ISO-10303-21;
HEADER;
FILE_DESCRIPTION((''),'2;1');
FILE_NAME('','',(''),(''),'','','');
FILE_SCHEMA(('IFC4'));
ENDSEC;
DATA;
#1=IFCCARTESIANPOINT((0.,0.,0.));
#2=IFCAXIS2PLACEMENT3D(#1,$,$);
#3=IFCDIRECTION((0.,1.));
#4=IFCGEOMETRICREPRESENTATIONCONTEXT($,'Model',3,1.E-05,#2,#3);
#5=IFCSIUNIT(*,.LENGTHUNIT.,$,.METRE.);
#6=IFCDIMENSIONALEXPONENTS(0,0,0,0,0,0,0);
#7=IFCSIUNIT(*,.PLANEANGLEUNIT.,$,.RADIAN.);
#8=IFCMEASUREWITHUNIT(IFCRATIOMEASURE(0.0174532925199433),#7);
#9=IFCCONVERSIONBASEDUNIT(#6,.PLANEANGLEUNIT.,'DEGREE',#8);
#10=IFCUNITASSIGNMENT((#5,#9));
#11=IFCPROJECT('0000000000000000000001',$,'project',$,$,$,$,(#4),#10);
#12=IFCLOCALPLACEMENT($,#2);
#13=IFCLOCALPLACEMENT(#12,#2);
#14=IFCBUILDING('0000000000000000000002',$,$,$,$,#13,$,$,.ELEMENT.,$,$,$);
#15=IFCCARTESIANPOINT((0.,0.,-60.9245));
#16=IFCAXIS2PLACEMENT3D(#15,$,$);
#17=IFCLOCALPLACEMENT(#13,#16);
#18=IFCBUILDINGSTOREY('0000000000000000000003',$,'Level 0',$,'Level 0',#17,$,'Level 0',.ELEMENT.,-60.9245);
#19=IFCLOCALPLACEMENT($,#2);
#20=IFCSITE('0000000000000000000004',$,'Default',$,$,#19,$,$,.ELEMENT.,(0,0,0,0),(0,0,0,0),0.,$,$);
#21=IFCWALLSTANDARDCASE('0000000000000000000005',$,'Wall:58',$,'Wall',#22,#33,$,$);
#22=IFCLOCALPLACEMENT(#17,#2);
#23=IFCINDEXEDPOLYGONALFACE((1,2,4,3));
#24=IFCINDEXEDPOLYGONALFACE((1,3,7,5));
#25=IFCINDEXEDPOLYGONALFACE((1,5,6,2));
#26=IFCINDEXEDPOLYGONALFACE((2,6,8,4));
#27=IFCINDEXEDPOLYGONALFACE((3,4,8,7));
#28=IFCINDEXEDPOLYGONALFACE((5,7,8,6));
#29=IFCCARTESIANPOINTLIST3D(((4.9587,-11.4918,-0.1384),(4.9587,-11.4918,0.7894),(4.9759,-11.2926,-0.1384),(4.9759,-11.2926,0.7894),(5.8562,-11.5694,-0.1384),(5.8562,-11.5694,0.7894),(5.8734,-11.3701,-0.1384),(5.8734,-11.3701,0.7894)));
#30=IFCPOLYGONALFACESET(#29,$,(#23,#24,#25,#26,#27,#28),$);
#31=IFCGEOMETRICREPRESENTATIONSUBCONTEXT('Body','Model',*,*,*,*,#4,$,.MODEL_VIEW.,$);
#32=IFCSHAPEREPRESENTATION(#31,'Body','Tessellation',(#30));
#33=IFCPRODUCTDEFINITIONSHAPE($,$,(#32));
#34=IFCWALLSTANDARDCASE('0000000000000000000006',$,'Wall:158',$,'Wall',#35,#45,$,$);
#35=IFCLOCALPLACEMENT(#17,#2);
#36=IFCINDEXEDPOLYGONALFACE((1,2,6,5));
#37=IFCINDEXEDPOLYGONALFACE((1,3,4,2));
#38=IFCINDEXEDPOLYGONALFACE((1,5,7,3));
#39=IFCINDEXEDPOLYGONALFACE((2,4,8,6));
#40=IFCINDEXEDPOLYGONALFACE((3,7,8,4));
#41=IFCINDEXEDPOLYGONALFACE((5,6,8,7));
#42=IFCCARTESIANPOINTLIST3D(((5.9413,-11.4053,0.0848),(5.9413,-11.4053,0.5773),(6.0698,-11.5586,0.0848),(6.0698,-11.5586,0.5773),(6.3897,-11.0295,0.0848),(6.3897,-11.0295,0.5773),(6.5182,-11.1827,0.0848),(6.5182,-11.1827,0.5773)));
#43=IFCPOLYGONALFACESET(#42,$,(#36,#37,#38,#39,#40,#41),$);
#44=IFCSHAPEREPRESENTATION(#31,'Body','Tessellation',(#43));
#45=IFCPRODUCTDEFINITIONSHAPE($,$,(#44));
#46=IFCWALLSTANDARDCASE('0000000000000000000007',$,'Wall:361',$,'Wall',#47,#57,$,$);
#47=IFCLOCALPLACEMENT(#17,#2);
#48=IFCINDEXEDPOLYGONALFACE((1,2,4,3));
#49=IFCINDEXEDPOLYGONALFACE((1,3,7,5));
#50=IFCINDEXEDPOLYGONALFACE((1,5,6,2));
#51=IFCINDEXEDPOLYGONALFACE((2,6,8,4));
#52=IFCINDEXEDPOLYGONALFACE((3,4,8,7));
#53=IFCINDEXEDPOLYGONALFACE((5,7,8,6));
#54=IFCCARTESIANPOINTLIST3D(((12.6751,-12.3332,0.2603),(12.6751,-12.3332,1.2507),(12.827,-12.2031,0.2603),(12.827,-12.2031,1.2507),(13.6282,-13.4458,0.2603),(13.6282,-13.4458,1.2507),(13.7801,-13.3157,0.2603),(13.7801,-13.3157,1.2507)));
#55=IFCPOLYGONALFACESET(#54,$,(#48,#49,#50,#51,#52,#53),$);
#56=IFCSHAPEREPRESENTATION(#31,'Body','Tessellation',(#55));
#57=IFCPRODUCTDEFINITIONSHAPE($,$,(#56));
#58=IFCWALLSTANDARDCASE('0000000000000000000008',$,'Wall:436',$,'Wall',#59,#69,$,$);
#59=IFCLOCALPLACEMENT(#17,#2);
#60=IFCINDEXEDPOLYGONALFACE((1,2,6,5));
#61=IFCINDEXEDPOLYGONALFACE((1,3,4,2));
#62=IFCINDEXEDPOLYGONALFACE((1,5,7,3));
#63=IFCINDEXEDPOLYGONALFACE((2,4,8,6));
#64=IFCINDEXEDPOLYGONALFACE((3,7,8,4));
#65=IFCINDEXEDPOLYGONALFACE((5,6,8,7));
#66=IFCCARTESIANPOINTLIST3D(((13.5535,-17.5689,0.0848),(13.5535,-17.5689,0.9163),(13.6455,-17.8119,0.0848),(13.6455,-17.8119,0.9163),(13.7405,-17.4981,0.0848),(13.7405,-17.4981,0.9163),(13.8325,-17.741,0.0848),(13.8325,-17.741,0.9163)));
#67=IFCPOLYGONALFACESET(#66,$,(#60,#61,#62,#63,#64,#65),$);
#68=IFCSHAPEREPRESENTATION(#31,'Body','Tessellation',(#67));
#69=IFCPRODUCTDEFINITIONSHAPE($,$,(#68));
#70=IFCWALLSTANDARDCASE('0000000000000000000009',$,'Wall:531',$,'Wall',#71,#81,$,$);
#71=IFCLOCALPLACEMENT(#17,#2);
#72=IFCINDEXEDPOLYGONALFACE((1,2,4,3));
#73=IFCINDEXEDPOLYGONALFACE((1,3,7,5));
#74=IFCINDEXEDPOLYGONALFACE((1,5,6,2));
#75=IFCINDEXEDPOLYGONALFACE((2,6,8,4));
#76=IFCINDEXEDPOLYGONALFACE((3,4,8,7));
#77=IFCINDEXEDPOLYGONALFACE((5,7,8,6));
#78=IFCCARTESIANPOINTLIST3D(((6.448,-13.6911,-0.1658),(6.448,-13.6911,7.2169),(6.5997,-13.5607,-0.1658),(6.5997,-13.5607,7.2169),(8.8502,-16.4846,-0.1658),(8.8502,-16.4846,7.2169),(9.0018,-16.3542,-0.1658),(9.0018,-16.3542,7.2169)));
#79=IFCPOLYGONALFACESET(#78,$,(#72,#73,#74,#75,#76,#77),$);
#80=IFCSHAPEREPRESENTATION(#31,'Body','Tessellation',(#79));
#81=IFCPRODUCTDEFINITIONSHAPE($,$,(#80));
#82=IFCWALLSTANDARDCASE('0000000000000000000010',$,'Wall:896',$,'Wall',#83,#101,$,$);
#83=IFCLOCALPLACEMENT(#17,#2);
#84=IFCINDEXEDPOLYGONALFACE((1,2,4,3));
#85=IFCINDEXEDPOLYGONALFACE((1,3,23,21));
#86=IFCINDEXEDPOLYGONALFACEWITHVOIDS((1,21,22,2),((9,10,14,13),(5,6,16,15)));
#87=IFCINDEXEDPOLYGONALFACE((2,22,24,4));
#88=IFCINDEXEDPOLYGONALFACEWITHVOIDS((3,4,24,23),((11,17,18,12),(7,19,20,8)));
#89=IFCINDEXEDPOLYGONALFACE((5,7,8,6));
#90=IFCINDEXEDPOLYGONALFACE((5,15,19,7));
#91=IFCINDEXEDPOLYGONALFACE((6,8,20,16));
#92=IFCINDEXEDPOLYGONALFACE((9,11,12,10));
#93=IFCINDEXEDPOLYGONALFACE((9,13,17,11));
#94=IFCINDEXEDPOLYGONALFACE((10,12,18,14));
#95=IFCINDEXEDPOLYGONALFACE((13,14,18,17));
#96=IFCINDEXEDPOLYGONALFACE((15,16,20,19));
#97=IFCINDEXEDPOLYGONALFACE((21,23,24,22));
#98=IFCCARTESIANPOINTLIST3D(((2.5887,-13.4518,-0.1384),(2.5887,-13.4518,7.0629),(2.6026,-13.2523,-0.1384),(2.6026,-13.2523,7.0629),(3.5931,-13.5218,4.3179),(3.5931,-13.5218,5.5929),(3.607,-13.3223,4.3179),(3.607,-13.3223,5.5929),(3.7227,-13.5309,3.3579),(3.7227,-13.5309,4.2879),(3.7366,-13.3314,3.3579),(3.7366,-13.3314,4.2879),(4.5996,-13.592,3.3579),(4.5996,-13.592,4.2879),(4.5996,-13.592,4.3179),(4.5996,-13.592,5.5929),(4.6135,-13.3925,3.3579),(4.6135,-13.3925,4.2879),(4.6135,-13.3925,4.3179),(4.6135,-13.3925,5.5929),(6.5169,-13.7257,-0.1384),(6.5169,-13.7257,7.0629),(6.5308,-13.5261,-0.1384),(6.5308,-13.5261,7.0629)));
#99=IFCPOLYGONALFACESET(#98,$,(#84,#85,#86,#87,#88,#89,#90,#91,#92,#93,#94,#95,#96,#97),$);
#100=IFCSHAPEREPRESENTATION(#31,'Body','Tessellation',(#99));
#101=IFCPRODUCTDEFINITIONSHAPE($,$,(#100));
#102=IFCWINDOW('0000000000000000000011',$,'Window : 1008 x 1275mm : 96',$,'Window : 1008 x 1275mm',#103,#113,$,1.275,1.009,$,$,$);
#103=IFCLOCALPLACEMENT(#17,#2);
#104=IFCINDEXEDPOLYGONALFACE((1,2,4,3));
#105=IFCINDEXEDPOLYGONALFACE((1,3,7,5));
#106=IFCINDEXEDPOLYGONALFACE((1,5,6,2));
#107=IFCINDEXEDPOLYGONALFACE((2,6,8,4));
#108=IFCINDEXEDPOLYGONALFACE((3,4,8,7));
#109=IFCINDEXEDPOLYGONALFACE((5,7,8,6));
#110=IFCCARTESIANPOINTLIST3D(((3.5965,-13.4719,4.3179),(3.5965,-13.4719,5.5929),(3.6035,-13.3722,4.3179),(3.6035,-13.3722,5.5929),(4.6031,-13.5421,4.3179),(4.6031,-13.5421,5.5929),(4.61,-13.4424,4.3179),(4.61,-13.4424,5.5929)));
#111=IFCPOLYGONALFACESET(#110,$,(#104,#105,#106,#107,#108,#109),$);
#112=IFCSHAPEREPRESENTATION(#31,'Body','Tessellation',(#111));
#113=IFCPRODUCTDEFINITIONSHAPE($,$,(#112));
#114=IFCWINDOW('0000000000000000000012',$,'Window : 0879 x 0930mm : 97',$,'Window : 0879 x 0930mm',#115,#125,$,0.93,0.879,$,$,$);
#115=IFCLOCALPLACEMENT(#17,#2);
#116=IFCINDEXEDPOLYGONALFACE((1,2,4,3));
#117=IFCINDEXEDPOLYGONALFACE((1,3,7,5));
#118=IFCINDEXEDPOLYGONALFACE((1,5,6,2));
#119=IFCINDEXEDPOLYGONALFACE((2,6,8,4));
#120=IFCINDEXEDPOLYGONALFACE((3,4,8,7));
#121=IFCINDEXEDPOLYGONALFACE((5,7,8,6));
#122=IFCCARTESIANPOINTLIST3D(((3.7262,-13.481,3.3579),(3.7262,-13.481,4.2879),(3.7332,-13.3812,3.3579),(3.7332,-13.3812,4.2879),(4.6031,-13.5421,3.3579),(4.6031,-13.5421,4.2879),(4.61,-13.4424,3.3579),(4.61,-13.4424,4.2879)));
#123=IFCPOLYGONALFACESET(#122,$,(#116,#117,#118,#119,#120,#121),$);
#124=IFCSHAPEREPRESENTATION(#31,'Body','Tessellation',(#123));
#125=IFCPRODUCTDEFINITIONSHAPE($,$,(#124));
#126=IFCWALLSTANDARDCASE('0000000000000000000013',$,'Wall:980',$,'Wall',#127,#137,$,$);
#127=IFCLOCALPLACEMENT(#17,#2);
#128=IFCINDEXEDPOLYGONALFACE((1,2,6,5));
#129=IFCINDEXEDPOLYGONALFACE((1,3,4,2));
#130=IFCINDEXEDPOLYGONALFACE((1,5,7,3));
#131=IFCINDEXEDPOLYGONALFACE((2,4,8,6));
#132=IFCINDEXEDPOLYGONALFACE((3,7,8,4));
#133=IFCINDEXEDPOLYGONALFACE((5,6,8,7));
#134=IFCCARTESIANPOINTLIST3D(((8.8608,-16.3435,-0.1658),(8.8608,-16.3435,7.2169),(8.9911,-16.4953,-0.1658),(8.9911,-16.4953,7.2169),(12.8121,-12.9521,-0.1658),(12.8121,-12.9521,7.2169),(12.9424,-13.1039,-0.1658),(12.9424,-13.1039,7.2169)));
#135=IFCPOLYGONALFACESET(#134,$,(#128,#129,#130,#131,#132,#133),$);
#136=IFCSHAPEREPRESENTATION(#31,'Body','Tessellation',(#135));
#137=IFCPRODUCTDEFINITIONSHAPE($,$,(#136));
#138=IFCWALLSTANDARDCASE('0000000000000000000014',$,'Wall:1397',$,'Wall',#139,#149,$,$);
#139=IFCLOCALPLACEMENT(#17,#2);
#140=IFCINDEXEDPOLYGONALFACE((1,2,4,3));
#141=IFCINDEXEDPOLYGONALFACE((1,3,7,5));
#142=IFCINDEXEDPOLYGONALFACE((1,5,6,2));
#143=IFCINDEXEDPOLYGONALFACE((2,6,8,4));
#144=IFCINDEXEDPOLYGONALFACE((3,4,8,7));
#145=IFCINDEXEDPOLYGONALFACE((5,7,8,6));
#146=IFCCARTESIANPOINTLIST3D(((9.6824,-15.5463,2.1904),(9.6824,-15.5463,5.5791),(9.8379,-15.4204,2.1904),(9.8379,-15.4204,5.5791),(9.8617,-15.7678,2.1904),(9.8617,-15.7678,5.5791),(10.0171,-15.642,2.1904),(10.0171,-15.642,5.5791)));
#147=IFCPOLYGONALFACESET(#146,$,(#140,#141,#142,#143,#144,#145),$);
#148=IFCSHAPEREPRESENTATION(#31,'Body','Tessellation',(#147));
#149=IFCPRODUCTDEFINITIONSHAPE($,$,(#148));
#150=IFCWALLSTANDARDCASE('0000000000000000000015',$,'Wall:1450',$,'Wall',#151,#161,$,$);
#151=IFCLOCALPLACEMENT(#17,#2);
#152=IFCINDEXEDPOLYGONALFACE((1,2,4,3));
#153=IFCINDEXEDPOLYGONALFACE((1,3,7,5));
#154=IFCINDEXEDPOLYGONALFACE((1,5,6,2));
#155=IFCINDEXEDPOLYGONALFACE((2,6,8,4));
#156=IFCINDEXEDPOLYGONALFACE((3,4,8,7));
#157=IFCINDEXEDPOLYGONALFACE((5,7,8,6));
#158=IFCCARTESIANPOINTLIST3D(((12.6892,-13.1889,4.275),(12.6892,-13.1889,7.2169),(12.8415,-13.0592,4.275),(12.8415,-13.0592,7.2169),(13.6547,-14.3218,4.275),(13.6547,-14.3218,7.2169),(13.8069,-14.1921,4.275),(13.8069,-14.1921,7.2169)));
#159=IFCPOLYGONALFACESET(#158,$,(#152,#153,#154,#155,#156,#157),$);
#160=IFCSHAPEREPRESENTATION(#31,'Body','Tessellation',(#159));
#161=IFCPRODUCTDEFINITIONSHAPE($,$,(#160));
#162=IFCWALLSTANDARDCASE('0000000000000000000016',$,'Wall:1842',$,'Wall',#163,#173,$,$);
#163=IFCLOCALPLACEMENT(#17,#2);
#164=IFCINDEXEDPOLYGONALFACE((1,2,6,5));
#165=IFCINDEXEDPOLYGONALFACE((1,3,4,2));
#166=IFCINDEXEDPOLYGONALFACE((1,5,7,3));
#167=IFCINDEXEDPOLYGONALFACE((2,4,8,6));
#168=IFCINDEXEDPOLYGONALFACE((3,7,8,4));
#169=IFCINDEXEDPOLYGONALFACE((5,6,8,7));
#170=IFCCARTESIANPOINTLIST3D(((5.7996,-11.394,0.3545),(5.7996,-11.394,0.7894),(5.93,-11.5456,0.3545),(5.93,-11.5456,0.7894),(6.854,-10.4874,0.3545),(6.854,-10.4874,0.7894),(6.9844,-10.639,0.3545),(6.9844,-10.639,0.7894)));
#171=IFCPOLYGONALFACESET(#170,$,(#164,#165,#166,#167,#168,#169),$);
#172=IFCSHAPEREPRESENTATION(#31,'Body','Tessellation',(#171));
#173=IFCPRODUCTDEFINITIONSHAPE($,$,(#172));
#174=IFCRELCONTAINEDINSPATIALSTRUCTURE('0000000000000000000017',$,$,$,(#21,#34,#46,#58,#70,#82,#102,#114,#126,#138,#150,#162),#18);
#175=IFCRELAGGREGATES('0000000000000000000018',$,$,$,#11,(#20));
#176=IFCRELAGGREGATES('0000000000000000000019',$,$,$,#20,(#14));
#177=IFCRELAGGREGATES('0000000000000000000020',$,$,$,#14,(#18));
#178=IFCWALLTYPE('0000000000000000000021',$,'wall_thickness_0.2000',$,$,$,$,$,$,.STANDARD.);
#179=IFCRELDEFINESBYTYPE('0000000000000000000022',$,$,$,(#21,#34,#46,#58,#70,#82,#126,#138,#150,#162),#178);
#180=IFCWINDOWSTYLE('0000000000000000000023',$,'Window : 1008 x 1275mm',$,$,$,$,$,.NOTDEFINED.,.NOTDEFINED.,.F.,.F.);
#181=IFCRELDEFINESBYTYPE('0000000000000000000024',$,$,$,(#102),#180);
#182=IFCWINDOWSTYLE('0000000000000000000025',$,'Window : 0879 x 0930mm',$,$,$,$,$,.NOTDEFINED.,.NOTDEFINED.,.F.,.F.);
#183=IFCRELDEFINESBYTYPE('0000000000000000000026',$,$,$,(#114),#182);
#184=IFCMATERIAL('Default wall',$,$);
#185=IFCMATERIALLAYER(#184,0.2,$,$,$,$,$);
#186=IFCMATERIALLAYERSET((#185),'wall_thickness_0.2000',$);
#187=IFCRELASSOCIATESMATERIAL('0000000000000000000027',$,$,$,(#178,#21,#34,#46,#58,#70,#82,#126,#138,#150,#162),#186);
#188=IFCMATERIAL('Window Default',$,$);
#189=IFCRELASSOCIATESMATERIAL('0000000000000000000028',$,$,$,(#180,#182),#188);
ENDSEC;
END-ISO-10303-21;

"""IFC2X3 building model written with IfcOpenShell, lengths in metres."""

from ifc_helpers import new_model, entity, si_unit, converted_unit, direction, frame, frame_2d, origin, origin_2d_with_axis, place, context, subcontext, project, spatial, polyline, rectangle, outline, extrude, source, transform, mapped, material, layer, layer_set, layer_usage, type_object, type_shapes, element, fill, save


model = new_model("IFC2X3")

# Units and contexts
model_context = context("Model", 3, precision=1e-05, world=origin(), true_north=direction((0.0, 1.0)))
body_context = subcontext(model_context, "Body", "Model", "MODEL_VIEW")
ifc_project = project(units=[si_unit("LENGTHUNIT", "METRE"), converted_unit("PLANEANGLEUNIT", "DEGREE", entity("IfcRatioMeasure", 0.0174532925199433), si_unit("PLANEANGLEUNIT", "RADIAN"), dimensions=[0, 0, 0, 0, 0, 0, 0])], contexts=[model_context])

# Site, building, storey
site_placement = place(None, origin())
site = spatial("IfcSite", under=ifc_project, at=site_placement, Name="Default", CompositionType="ELEMENT", RefLatitude=(0, 0, 0, 0), RefLongitude=(0, 0, 0, 0), RefElevation=0.0)
placement_1 = place(None, origin())
building_placement = place(placement_1, origin())
building = spatial("IfcBuilding", under=site, at=building_placement, CompositionType="ELEMENT")
storey_placement = place(building_placement, frame((0.0, 0.0, -60.9245)))
storey = spatial("IfcBuildingStorey", under=building, at=storey_placement, Name="Level 0", ObjectType="Level 0", LongName="Level 0", CompositionType="ELEMENT", Elevation=-60.9245)

# Walls
ifc_material_1 = material(Name="Default wall")
ifc_layer = layer(ifc_material_1, 0.2)
ifc_layer_set = layer_set([ifc_layer], Name="wall_thickness_0.2000")
ifc_layer_usage = layer_usage(ifc_layer_set, "AXIS2", "POSITIVE", -0.1)
wall_type = type_object("IfcWallType", Name="wall_thickness_0.2000", PredefinedType="STANDARD", material=ifc_layer_set)
placement_2 = place(building_placement, frame((0.0, 0.0, -61.0629)))
wall_1_placement = place(placement_2, frame((5.8648, -11.4698, 0.0), z_axis=(0.0, 0.0, 1.0), x_axis=(-0.996283, 0.086143, 0.0)))
element("IfcWallStandardCase", 1, at=wall_1_placement, inside=storey, type_object=wall_type, material=ifc_layer_usage, Name="Wall:58", ObjectType="Wall", context=body_context, shape_type="SweptSolid", body=[
    extrude(outline(polyline([(0.9008, -0.1), (0.9008, 0.1), (0.0, 0.1), (0.0, -0.1), (0.9008, -0.1)])), origin(), (0.0, 0.0, 1.0), 0.9278),
])
placement_3 = place(building_placement, frame((0.0, 0.0, -60.8397)))
wall_2_placement = place(placement_3, frame((6.0056, -11.4819, 0.0), z_axis=(0.0, 0.0, 1.0), x_axis=(0.766395, 0.64237, 0.0)))
element("IfcWallStandardCase", 2, at=wall_2_placement, inside=storey, type_object=wall_type, material=ifc_layer_usage, Name="Wall:158", ObjectType="Wall", context=body_context, shape_type="SweptSolid", body=[
    extrude(outline(polyline([(0.5851, -0.1), (0.5851, 0.1), (0.0, 0.1), (0.0, -0.1), (0.5851, -0.1)])), origin(), (0.0, 0.0, 1.0), 0.4925),
])
placement_4 = place(building_placement, frame((0.0, 0.0, -60.6642)))
wall_3_placement = place(placement_4, frame((12.7511, -12.2682, 0.0), z_axis=(0.0, 0.0, 1.0), x_axis=(0.650589, -0.75943, 0.0)))
element("IfcWallStandardCase", 3, at=wall_3_placement, inside=storey, type_object=wall_type, material=ifc_layer_usage, Name="Wall:361", ObjectType="Wall", context=body_context, shape_type="SweptSolid", body=[
    extrude(outline(polyline([(1.465, -0.1), (1.465, 0.1), (0.0, 0.1), (0.0, -0.1), (1.465, -0.1)])), origin(), (0.0, 0.0, 1.0), 0.9904),
])
placement_5 = place(building_placement, frame((0.0, 0.0, -60.8397)))
wall_4_placement = place(placement_5, frame((13.647, -17.5335, 0.0), z_axis=(0.0, 0.0, 1.0), x_axis=(0.354198, -0.93517, 0.0)))
element("IfcWallStandardCase", 4, at=wall_4_placement, inside=storey, type_object=wall_type, material=ifc_layer_usage, Name="Wall:436", ObjectType="Wall", context=body_context, shape_type="SweptSolid", body=[
    extrude(outline(polyline([(0.2598, -0.1), (0.2598, 0.1), (0.0, 0.1), (0.0, -0.1), (0.2598, -0.1)])), origin(), (0.0, 0.0, 1.0), 0.8315),
])
placement_6 = place(building_placement, frame((0.0, 0.0, -61.0903)))
wall_5_placement = place(placement_6, frame((6.5239, -13.6259, 0.0), z_axis=(0.0, 0.0, 1.0), x_axis=(0.651998, -0.758221, 0.0)))
element("IfcWallStandardCase", 5, at=wall_5_placement, inside=storey, type_object=wall_type, material=ifc_layer_usage, Name="Wall:531", ObjectType="Wall", context=body_context, shape_type="SweptSolid", body=[
    extrude(outline(polyline([(3.6842, -0.1), (3.6842, 0.1), (0.0, 0.1), (0.0, -0.1), (3.6842, -0.1)])), origin(), (0.0, 0.0, 1.0), 7.3827),
])

# Wall, openings, windows
placement_7 = place(building_placement, frame((0.0, 0.0, -61.0629)))
wall_6_placement = place(placement_7, frame((6.5239, -13.6259, 0.0), z_axis=(0.0, 0.0, 1.0), x_axis=(-0.997579, 0.069546, 0.0)))
wall_6 = element("IfcWallStandardCase", 6, at=wall_6_placement, inside=storey, type_object=wall_type, material=ifc_layer_usage, Name="Wall:896", ObjectType="Wall", context=body_context, shape_type="SweptSolid", body=[
    extrude(outline(polyline([(3.9377, -0.1), (3.9377, 0.1), (0.0, 0.1), (0.0, -0.1), (3.9377, -0.1)])), origin(), (0.0, 0.0, 1.0), 7.2012),
])
opening_1_placement = place(wall_6_placement, frame((1.9219, -0.1, 4.4562)))
opening_1 = element("IfcOpeningElement", 7, at=opening_1_placement, cuts=wall_6, ObjectType="Opening", context=body_context, shape_type="SweptSolid", body=[
    extrude(rectangle(XDim=1.009, YDim=1.275, at=frame_2d((0.6375, 0.5045), x_axis=(0.0, 1.0))), frame((0.0, 0.0, 0.0), z_axis=(0.0, 1.0, 0.0), x_axis=(0.0, 0.0, 1.0)), (0.0, 0.0, 1.0), 0.2),
])
opening_2_placement = place(wall_6_placement, frame((1.9219, -0.1, 3.4962)))
opening_2 = element("IfcOpeningElement", 8, at=opening_2_placement, cuts=wall_6, ObjectType="Opening", context=body_context, shape_type="SweptSolid", body=[
    extrude(rectangle(XDim=0.879, YDim=0.93, at=frame_2d((0.465, 0.4395), x_axis=(0.0, 1.0))), frame((0.0, 0.0, 0.0), z_axis=(0.0, 1.0, 0.0), x_axis=(0.0, 0.0, 1.0)), (0.0, 0.0, 1.0), 0.2),
])
ifc_material_2 = material(Name="Window Default")
window_style_1 = type_object("IfcWindowStyle", Name="Window : 1008 x 1275mm", ConstructionType="NOTDEFINED", OperationType="NOTDEFINED", ParameterTakesPrecedence=False, Sizeable=False, material=ifc_material_2)
shared_shape_1 = source(origin(), body_context, "Body", "SweptSolid", [
    extrude(rectangle(XDim=0.1, YDim=1.009, at=origin_2d_with_axis()), frame((0.5045, 0.1, 0.0), z_axis=(0.0, 0.0, 1.0), x_axis=(0.0, 1.0, 0.0)), (0.0, 0.0, 1.0), 1.275),
])
type_shapes(window_style_1, [shared_shape_1])
window_1_placement = place(opening_1_placement, origin())
window_1 = element("IfcWindow", 9, at=window_1_placement, inside=storey, type_object=window_style_1, Name="Window : 1008 x 1275mm : 96", ObjectType="Window : 1008 x 1275mm", OverallHeight=1.275, OverallWidth=1.009, context=body_context, shape_type="MappedRepresentation", body=[
    mapped(shared_shape_1, transform((0.0, 0.0, 0.0), scale=1.0)),
])
fill(opening_1, window_1)
window_style_2 = type_object("IfcWindowStyle", Name="Window : 0879 x 0930mm", ConstructionType="NOTDEFINED", OperationType="NOTDEFINED", ParameterTakesPrecedence=False, Sizeable=False, material=ifc_material_2)
shared_shape_2 = source(origin(), body_context, "Body", "SweptSolid", [
    extrude(rectangle(XDim=0.1, YDim=0.879, at=origin_2d_with_axis()), frame((0.4395, 0.1, 0.0), z_axis=(0.0, 0.0, 1.0), x_axis=(0.0, 1.0, 0.0)), (0.0, 0.0, 1.0), 0.93),
])
type_shapes(window_style_2, [shared_shape_2])
window_2_placement = place(opening_2_placement, origin())
window_2 = element("IfcWindow", 10, at=window_2_placement, inside=storey, type_object=window_style_2, Name="Window : 0879 x 0930mm : 97", ObjectType="Window : 0879 x 0930mm", OverallHeight=0.93, OverallWidth=0.879, context=body_context, shape_type="MappedRepresentation", body=[
    mapped(shared_shape_2, transform((0.0, 0.0, 0.0), scale=1.0)),
])
fill(opening_2, window_2)

# Walls
placement_8 = place(building_placement, frame((0.0, 0.0, -61.0903)))
wall_7_placement = place(placement_8, frame((12.8772, -13.028, 0.0), z_axis=(0.0, 0.0, 1.0), x_axis=(-0.758822, -0.651298, 0.0)))
element("IfcWallStandardCase", 11, at=wall_7_placement, inside=storey, type_object=wall_type, material=ifc_layer_usage, Name="Wall:980", ObjectType="Wall", context=body_context, shape_type="SweptSolid", body=[
    extrude(outline(polyline([(5.2071, -0.1), (5.2071, 0.1), (0.0, 0.1), (0.0, -0.1), (5.2071, -0.1)])), origin(), (0.0, 0.0, 1.0), 7.3827),
])
placement_9 = place(building_placement, frame((0.0, 0.0, -58.7341)))
wall_8_placement = place(placement_9, frame((9.7601, -15.4833, 0.0), z_axis=(0.0, 0.0, 1.0), x_axis=(0.629056, -0.77736, 0.0)))
element("IfcWallStandardCase", 12, at=wall_8_placement, inside=storey, type_object=wall_type, material=ifc_layer_usage, Name="Wall:1397", ObjectType="Wall", context=body_context, shape_type="SweptSolid", body=[
    extrude(outline(polyline([(0.285, -0.1), (0.285, 0.1), (0.0, 0.1), (0.0, -0.1), (0.285, -0.1)])), origin(), (0.0, 0.0, 1.0), 3.3887),
])
placement_10 = place(building_placement, frame((0.0, 0.0, -56.6495)))
wall_9_placement = place(placement_10, frame((13.7308, -14.257, 0.0), z_axis=(0.0, 0.0, 1.0), x_axis=(-0.648602, 0.761128, 0.0)))
element("IfcWallStandardCase", 13, at=wall_9_placement, inside=storey, type_object=wall_type, material=ifc_layer_usage, Name="Wall:1450", ObjectType="Wall", context=body_context, shape_type="SweptSolid", body=[
    extrude(outline(polyline([(1.4885, -0.1), (1.4885, 0.1), (0.0, 0.1), (0.0, -0.1), (1.4885, -0.1)])), origin(), (0.0, 0.0, 1.0), 2.942),
])
placement_11 = place(building_placement, frame((0.0, 0.0, -60.57)))
wall_10_placement = place(placement_11, frame((5.8648, -11.4698, 0.0), z_axis=(0.0, 0.0, 1.0), x_axis=(0.75826, 0.651953, 0.0)))
element("IfcWallStandardCase", 14, at=wall_10_placement, inside=storey, type_object=wall_type, material=ifc_layer_usage, Name="Wall:1842", ObjectType="Wall", context=body_context, shape_type="SweptSolid", body=[
    extrude(outline(polyline([(1.3906, -0.1), (1.3906, 0.1), (0.0, 0.1), (0.0, -0.1), (1.3906, -0.1)])), origin(), (0.0, 0.0, 1.0), 0.4349),
])

save(model, "model.ifc")
